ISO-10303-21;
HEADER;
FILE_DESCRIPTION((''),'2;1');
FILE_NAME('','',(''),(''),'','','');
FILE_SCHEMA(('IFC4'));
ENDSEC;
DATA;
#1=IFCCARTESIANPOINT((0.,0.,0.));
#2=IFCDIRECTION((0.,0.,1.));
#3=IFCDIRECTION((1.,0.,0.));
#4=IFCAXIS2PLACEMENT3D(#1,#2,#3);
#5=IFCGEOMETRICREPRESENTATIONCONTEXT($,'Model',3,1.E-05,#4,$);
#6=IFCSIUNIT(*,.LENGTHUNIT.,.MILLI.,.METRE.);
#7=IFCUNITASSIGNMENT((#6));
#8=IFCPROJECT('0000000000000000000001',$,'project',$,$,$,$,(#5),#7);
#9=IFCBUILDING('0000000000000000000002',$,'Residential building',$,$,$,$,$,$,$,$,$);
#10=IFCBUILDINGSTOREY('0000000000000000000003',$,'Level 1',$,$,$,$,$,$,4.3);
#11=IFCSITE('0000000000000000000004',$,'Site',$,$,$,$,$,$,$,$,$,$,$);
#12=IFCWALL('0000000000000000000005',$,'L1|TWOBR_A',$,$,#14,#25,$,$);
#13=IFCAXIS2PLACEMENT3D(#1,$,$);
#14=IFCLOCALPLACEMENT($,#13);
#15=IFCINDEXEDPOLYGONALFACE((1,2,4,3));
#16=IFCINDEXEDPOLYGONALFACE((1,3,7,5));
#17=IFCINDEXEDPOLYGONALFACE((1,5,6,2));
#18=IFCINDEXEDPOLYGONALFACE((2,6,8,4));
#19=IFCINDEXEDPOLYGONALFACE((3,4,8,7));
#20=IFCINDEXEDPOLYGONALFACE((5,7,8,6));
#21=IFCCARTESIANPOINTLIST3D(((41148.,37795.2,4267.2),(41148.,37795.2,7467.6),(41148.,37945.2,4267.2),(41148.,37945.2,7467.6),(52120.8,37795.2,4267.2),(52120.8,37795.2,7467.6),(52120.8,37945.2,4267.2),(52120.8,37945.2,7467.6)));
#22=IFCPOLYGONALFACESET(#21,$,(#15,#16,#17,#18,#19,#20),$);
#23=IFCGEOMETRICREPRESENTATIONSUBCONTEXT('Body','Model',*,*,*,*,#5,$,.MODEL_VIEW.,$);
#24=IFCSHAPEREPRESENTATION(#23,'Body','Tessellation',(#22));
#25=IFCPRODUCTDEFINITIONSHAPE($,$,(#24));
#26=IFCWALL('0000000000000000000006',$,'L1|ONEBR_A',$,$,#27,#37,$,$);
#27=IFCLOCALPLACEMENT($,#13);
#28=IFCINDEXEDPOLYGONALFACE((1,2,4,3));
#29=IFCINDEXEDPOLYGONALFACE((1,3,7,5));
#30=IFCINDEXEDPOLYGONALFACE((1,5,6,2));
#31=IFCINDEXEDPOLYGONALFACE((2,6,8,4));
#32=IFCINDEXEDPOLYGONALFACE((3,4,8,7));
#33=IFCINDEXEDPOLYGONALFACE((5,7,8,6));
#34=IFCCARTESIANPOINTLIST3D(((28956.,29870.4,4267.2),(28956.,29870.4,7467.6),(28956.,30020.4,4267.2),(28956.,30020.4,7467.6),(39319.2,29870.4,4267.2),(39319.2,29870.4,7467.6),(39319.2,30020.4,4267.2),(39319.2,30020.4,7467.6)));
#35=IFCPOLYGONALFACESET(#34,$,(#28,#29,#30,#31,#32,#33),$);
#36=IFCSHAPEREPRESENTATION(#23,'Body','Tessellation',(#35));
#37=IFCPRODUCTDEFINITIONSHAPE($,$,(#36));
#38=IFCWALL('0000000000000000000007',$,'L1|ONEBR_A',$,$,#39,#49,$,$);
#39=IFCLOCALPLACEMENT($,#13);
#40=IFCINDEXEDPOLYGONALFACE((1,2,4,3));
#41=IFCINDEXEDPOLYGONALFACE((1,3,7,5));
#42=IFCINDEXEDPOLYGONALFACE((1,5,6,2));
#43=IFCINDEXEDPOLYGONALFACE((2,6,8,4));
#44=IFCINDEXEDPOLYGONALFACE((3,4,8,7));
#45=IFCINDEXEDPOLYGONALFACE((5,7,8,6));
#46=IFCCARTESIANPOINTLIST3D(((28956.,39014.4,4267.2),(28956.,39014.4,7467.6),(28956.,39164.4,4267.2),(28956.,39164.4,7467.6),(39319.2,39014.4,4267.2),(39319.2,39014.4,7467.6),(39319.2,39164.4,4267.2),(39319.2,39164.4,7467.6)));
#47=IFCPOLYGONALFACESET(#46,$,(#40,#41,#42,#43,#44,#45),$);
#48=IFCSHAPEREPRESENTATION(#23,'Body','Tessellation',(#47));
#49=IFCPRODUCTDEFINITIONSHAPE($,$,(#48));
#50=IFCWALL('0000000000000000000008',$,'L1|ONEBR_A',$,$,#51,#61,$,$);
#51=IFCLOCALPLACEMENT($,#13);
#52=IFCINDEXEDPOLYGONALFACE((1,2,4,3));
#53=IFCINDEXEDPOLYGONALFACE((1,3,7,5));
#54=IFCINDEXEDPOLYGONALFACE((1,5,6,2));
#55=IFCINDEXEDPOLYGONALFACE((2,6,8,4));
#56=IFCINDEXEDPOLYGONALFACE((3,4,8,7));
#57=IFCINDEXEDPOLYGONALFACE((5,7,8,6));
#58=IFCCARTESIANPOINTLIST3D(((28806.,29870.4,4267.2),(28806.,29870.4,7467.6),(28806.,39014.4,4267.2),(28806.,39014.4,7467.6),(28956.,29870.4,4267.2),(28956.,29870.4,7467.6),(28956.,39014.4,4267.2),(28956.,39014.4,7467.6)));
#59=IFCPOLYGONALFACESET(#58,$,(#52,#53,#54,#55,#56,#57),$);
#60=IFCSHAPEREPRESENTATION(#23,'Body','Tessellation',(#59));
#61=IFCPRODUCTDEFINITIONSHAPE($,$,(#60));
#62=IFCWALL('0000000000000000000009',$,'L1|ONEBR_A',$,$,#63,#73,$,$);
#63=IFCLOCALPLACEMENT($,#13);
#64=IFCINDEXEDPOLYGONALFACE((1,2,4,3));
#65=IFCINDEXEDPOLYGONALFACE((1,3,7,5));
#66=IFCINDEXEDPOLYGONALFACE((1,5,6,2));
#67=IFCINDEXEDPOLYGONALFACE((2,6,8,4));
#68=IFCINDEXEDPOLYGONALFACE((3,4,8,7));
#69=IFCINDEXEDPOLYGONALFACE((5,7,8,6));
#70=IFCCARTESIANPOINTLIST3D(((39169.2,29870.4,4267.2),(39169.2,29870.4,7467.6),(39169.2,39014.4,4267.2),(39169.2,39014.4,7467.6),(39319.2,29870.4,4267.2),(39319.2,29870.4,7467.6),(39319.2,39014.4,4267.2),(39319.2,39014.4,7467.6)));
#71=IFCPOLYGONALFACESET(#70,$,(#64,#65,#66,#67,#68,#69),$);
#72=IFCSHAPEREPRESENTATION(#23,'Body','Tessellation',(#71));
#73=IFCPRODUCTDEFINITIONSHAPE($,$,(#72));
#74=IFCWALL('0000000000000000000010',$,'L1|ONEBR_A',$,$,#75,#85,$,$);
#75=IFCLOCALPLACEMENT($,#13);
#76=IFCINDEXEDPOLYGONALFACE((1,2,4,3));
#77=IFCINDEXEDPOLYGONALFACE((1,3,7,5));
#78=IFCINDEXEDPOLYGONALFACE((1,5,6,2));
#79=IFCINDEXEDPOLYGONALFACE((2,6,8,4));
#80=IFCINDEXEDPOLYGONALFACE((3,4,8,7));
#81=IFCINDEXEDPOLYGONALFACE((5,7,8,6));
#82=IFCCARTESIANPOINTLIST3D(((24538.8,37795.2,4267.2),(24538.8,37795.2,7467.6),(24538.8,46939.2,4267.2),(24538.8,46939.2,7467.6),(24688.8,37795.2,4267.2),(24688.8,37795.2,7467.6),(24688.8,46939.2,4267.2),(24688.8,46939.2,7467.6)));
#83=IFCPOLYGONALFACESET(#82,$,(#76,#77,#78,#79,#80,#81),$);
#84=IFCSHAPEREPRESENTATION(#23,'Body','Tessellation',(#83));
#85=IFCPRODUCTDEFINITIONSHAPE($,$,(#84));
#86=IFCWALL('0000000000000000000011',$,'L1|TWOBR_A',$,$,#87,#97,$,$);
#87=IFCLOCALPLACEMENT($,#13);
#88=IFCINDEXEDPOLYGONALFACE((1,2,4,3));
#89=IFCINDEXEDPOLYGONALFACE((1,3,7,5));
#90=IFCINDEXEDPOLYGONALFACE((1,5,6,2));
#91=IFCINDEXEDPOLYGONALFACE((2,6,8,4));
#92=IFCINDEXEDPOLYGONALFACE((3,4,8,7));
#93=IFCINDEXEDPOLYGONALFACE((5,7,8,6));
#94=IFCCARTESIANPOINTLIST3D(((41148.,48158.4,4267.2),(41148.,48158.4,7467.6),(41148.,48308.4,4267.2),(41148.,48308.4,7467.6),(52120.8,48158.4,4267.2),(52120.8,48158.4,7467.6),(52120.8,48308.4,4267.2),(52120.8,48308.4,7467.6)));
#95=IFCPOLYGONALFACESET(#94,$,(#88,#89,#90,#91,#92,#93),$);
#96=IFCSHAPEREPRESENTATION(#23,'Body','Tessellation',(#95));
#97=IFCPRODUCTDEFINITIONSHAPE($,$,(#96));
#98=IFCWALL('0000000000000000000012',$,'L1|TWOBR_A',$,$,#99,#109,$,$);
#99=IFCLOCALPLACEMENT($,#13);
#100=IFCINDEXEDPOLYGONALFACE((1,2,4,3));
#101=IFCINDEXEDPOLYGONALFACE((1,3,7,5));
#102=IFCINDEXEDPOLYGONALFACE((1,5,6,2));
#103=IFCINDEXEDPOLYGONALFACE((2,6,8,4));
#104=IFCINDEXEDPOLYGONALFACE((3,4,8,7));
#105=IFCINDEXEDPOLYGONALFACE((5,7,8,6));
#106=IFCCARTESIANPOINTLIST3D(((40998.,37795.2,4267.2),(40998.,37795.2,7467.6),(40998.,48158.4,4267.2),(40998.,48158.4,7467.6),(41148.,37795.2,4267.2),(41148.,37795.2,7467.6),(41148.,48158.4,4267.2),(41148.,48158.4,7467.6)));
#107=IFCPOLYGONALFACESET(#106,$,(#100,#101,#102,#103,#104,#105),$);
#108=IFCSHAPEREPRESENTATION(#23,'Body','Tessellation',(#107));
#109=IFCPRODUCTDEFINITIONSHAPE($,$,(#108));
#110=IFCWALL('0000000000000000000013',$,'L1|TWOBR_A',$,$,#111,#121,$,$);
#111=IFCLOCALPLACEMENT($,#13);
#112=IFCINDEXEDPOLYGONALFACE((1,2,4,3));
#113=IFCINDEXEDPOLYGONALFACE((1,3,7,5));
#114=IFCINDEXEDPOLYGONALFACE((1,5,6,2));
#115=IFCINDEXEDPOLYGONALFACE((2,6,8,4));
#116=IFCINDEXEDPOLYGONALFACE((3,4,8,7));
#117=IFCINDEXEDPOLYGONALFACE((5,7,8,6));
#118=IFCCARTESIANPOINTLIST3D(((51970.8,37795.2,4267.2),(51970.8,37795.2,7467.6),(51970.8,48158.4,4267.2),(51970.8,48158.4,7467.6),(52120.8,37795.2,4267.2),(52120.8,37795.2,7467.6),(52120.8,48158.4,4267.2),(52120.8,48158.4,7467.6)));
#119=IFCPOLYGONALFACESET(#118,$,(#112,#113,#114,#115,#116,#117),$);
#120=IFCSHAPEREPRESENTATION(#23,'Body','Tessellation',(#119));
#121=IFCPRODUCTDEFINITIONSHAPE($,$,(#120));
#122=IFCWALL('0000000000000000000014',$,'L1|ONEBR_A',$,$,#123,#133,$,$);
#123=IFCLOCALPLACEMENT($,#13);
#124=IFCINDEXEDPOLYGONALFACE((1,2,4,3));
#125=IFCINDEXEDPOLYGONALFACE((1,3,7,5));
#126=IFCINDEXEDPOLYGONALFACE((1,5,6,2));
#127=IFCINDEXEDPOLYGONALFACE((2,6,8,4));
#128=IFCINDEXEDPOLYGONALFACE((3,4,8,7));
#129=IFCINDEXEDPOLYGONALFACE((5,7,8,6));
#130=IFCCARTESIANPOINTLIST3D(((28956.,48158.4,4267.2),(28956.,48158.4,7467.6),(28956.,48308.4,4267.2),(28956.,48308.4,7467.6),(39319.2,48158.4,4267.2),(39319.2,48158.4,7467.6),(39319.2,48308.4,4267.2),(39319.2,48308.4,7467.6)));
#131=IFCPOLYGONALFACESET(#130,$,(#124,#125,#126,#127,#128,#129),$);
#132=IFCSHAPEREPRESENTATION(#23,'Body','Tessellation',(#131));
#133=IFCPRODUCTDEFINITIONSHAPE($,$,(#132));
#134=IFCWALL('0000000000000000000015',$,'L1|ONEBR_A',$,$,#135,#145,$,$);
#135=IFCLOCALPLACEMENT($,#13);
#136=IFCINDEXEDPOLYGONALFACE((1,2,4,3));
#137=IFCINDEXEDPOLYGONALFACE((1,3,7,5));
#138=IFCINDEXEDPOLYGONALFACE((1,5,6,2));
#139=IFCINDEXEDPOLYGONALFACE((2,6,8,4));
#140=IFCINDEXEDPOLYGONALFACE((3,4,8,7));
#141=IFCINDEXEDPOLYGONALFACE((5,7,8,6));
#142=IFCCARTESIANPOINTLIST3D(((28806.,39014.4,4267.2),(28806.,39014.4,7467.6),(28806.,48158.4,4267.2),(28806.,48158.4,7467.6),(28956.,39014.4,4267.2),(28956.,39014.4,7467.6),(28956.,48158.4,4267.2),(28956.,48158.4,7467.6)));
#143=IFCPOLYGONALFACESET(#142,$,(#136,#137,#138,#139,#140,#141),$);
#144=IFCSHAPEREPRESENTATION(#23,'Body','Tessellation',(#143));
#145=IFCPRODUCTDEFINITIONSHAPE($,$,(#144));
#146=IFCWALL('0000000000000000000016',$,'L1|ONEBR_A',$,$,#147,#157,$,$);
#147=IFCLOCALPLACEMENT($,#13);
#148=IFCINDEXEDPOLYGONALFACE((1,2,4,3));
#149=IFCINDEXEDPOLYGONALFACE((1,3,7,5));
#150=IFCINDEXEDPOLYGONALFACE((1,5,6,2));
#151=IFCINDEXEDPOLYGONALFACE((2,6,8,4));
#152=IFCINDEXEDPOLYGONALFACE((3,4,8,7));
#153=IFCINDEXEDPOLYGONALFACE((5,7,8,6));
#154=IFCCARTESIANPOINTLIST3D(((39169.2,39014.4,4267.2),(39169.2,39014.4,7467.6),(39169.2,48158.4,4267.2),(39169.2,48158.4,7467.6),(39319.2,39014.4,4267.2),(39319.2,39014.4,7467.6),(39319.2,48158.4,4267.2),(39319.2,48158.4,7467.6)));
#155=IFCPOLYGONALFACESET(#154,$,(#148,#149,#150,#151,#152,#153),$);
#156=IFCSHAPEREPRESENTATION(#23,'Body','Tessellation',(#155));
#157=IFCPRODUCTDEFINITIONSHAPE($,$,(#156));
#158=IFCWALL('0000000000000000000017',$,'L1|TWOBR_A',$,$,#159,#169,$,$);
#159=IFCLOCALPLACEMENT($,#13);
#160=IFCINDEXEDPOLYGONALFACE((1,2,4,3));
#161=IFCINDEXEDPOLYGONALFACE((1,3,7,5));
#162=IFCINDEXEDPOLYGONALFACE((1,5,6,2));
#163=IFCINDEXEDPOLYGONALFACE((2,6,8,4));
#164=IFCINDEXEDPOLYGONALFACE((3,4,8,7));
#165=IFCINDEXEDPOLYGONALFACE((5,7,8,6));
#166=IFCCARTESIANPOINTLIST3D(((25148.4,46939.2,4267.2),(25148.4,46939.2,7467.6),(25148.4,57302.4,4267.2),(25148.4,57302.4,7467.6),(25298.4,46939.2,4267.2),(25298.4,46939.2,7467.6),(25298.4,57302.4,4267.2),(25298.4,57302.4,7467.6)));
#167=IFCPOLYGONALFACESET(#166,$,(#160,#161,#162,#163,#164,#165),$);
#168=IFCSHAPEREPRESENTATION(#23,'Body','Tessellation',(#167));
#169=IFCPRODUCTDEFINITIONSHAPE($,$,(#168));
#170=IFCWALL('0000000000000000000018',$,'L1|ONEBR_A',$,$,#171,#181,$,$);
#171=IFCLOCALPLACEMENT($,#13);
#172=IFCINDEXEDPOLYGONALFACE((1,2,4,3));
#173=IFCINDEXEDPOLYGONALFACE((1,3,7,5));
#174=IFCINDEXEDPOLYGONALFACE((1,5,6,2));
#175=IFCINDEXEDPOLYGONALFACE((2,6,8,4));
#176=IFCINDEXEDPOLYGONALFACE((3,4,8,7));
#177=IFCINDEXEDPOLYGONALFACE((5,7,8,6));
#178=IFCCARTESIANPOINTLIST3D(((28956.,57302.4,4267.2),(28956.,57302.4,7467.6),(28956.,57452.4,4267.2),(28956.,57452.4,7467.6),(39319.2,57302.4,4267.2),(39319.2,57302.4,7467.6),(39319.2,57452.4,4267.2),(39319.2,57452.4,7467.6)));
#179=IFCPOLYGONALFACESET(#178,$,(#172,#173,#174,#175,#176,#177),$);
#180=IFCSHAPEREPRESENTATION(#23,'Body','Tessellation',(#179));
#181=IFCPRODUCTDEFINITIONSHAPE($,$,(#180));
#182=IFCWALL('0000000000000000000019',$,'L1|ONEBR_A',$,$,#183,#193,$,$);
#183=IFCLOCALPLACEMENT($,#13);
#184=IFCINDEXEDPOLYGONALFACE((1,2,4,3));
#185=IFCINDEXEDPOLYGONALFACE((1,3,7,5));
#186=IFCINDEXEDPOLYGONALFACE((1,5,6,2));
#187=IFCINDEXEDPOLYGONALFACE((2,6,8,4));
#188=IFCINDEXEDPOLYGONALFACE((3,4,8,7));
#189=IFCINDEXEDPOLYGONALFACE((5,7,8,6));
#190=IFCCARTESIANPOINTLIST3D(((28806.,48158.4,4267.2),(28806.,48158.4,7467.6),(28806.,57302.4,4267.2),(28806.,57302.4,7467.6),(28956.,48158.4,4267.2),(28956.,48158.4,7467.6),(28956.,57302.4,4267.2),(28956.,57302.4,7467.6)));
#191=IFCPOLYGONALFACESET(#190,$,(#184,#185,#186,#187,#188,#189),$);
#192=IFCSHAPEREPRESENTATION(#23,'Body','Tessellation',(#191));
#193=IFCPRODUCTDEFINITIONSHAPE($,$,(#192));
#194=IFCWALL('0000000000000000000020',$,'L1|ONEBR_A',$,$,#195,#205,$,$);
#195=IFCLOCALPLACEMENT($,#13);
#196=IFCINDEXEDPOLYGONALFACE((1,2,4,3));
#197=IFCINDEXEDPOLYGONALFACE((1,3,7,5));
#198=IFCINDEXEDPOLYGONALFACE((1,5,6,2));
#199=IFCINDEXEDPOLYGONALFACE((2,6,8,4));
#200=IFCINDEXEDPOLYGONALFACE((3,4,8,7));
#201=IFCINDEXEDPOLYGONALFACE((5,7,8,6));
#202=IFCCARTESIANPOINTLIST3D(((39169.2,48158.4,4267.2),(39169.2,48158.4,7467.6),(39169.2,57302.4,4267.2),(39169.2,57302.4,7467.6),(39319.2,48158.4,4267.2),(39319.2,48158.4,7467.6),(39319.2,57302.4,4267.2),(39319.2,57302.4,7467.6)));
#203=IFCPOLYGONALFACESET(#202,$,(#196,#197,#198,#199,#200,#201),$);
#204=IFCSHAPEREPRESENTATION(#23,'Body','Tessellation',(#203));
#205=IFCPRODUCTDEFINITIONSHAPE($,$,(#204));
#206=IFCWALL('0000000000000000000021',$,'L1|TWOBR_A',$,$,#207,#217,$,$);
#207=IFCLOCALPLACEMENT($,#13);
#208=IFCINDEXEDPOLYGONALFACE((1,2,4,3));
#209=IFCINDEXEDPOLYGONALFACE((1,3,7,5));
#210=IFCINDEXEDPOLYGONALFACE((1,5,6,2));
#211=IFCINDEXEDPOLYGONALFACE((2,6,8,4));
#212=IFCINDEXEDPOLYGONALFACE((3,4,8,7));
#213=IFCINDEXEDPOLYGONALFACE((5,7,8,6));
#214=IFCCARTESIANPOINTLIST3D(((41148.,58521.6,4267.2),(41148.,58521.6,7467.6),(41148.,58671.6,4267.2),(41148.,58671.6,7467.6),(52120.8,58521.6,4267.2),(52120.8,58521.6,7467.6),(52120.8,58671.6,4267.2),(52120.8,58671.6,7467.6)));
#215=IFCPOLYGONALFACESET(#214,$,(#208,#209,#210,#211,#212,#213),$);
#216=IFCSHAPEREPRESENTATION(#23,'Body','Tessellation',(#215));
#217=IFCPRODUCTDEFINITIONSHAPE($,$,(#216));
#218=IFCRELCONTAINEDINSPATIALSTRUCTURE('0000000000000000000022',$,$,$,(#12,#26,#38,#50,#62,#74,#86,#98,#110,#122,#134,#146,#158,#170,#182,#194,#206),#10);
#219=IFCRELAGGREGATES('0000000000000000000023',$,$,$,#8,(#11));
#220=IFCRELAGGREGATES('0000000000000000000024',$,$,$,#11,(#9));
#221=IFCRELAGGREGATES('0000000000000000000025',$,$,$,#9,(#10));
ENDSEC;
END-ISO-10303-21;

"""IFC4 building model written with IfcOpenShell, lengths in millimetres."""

from ifc_helpers import new_model, si_unit, frame, origin_with_axes, place, context, subcontext, project, spatial, indexed_curve, outline, extrude, element, save


model = new_model("IFC4")

# Units and contexts
model_context = context("Model", 3, precision=1e-05, world=origin_with_axes())
body_context = subcontext(model_context, "Body", "Model", "MODEL_VIEW")
ifc_project = project(units=[si_unit("LENGTHUNIT", "METRE", prefix="MILLI")], contexts=[model_context])

# Site, building, storey
site = spatial("IfcSite", under=ifc_project, Name="Site")
building = spatial("IfcBuilding", under=site, Name="Residential building")
storey = spatial("IfcBuildingStorey", under=building, Name="Level 1", Elevation=4.3)

# Walls
wall_1_placement = place(None, frame((41148.0, 37795.2, 4267.2), z_axis=(0.0, 0.0, 1.0), x_axis=(1.0, 0.0, 0.0)))
element("IfcWall", 1, at=wall_1_placement, inside=storey, Name="L1|TWOBR_A", context=body_context, shape_type="SweptSolid", body=[
    extrude(outline(indexed_curve([(0.0, 0.0), (0.0, 150.0), (10972.8, 150.0), (10972.8, 0.0), (0.0, 0.0)], self_intersect=False)), origin_with_axes(), (0.0, 0.0, 1.0), 3200.4),
])
for number, where, z_axis, x_axis, name in (
    (2, (28956.0, 29870.4, 4267.2), (0.0, 0.0, 1.0), (1.0, 0.0, 0.0), "L1|ONEBR_A"),
    (3, (28956.0, 39014.4, 4267.2), (0.0, 0.0, 1.0), (1.0, 0.0, 0.0), "L1|ONEBR_A"),
):
    element("IfcWall", number, at=place(None, frame(where, z_axis=z_axis, x_axis=x_axis)), inside=storey, Name=name, context=body_context, shape_type="SweptSolid", body=[
        extrude(outline(indexed_curve([(0.0, 0.0), (0.0, 150.0), (10363.2, 150.0), (10363.2, 0.0), (0.0, 0.0)], self_intersect=False)), origin_with_axes(), (0.0, 0.0, 1.0), 3200.4),
    ])
for number, where, z_axis, x_axis, name in (
    (4, (28956.0, 29870.4, 4267.2), (0.0, 0.0, 1.0), (0.0, 1.0, 0.0), "L1|ONEBR_A"),
    (5, (39319.2, 29870.4, 4267.2), (0.0, 0.0, 1.0), (0.0, 1.0, 0.0), "L1|ONEBR_A"),
    (6, (24688.8, 37795.2, 4267.2), (0.0, 0.0, 1.0), (0.0, 1.0, 0.0), "L1|ONEBR_A"),
):
    element("IfcWall", number, at=place(None, frame(where, z_axis=z_axis, x_axis=x_axis)), inside=storey, Name=name, context=body_context, shape_type="SweptSolid", body=[
        extrude(outline(indexed_curve([(0.0, 0.0), (0.0, 150.0), (9144.0, 150.0), (9144.0, 0.0), (0.0, 0.0)], self_intersect=False)), origin_with_axes(), (0.0, 0.0, 1.0), 3200.4),
    ])
for number, where, z_axis, x_axis, name in (
    (7, (41148.0, 48158.4, 4267.2), (0.0, 0.0, 1.0), (1.0, 0.0, 0.0), "L1|TWOBR_A"),
):
    element("IfcWall", number, at=place(None, frame(where, z_axis=z_axis, x_axis=x_axis)), inside=storey, Name=name, context=body_context, shape_type="SweptSolid", body=[
        extrude(outline(indexed_curve([(0.0, 0.0), (0.0, 150.0), (10972.8, 150.0), (10972.8, 0.0), (0.0, 0.0)], self_intersect=False)), origin_with_axes(), (0.0, 0.0, 1.0), 3200.4),
    ])
for number, where, z_axis, x_axis, name in (
    (8, (41148.0, 37795.2, 4267.2), (0.0, 0.0, 1.0), (0.0, 1.0, 0.0), "L1|TWOBR_A"),
    (9, (52120.8, 37795.2, 4267.2), (0.0, 0.0, 1.0), (0.0, 1.0, 0.0), "L1|TWOBR_A"),
    (10, (28956.0, 48158.4, 4267.2), (0.0, 0.0, 1.0), (1.0, 0.0, 0.0), "L1|ONEBR_A"),
):
    element("IfcWall", number, at=place(None, frame(where, z_axis=z_axis, x_axis=x_axis)), inside=storey, Name=name, context=body_context, shape_type="SweptSolid", body=[
        extrude(outline(indexed_curve([(0.0, 0.0), (0.0, 150.0), (10363.2, 150.0), (10363.2, 0.0), (0.0, 0.0)], self_intersect=False)), origin_with_axes(), (0.0, 0.0, 1.0), 3200.4),
    ])
for number, where, z_axis, x_axis, name in (
    (11, (28956.0, 39014.4, 4267.2), (0.0, 0.0, 1.0), (0.0, 1.0, 0.0), "L1|ONEBR_A"),
    (12, (39319.2, 39014.4, 4267.2), (0.0, 0.0, 1.0), (0.0, 1.0, 0.0), "L1|ONEBR_A"),
):
    element("IfcWall", number, at=place(None, frame(where, z_axis=z_axis, x_axis=x_axis)), inside=storey, Name=name, context=body_context, shape_type="SweptSolid", body=[
        extrude(outline(indexed_curve([(0.0, 0.0), (0.0, 150.0), (9144.0, 150.0), (9144.0, 0.0), (0.0, 0.0)], self_intersect=False)), origin_with_axes(), (0.0, 0.0, 1.0), 3200.4),
    ])
for number, where, z_axis, x_axis, name in (
    (13, (25298.4, 46939.2, 4267.2), (0.0, 0.0, 1.0), (0.0, 1.0, 0.0), "L1|TWOBR_A"),
    (14, (28956.0, 57302.4, 4267.2), (0.0, 0.0, 1.0), (1.0, 0.0, 0.0), "L1|ONEBR_A"),
):
    element("IfcWall", number, at=place(None, frame(where, z_axis=z_axis, x_axis=x_axis)), inside=storey, Name=name, context=body_context, shape_type="SweptSolid", body=[
        extrude(outline(indexed_curve([(0.0, 0.0), (0.0, 150.0), (10363.2, 150.0), (10363.2, 0.0), (0.0, 0.0)], self_intersect=False)), origin_with_axes(), (0.0, 0.0, 1.0), 3200.4),
    ])
for number, where, z_axis, x_axis, name in (
    (15, (28956.0, 48158.4, 4267.2), (0.0, 0.0, 1.0), (0.0, 1.0, 0.0), "L1|ONEBR_A"),
    (16, (39319.2, 48158.4, 4267.2), (0.0, 0.0, 1.0), (0.0, 1.0, 0.0), "L1|ONEBR_A"),
):
    element("IfcWall", number, at=place(None, frame(where, z_axis=z_axis, x_axis=x_axis)), inside=storey, Name=name, context=body_context, shape_type="SweptSolid", body=[
        extrude(outline(indexed_curve([(0.0, 0.0), (0.0, 150.0), (9144.0, 150.0), (9144.0, 0.0), (0.0, 0.0)], self_intersect=False)), origin_with_axes(), (0.0, 0.0, 1.0), 3200.4),
    ])
for number, where, z_axis, x_axis, name in (
    (17, (41148.0, 58521.6, 4267.2), (0.0, 0.0, 1.0), (1.0, 0.0, 0.0), "L1|TWOBR_A"),
):
    element("IfcWall", number, at=place(None, frame(where, z_axis=z_axis, x_axis=x_axis)), inside=storey, Name=name, context=body_context, shape_type="SweptSolid", body=[
        extrude(outline(indexed_curve([(0.0, 0.0), (0.0, 150.0), (10972.8, 150.0), (10972.8, 0.0), (0.0, 0.0)], self_intersect=False)), origin_with_axes(), (0.0, 0.0, 1.0), 3200.4),
    ])

save(model, "model.ifc")
